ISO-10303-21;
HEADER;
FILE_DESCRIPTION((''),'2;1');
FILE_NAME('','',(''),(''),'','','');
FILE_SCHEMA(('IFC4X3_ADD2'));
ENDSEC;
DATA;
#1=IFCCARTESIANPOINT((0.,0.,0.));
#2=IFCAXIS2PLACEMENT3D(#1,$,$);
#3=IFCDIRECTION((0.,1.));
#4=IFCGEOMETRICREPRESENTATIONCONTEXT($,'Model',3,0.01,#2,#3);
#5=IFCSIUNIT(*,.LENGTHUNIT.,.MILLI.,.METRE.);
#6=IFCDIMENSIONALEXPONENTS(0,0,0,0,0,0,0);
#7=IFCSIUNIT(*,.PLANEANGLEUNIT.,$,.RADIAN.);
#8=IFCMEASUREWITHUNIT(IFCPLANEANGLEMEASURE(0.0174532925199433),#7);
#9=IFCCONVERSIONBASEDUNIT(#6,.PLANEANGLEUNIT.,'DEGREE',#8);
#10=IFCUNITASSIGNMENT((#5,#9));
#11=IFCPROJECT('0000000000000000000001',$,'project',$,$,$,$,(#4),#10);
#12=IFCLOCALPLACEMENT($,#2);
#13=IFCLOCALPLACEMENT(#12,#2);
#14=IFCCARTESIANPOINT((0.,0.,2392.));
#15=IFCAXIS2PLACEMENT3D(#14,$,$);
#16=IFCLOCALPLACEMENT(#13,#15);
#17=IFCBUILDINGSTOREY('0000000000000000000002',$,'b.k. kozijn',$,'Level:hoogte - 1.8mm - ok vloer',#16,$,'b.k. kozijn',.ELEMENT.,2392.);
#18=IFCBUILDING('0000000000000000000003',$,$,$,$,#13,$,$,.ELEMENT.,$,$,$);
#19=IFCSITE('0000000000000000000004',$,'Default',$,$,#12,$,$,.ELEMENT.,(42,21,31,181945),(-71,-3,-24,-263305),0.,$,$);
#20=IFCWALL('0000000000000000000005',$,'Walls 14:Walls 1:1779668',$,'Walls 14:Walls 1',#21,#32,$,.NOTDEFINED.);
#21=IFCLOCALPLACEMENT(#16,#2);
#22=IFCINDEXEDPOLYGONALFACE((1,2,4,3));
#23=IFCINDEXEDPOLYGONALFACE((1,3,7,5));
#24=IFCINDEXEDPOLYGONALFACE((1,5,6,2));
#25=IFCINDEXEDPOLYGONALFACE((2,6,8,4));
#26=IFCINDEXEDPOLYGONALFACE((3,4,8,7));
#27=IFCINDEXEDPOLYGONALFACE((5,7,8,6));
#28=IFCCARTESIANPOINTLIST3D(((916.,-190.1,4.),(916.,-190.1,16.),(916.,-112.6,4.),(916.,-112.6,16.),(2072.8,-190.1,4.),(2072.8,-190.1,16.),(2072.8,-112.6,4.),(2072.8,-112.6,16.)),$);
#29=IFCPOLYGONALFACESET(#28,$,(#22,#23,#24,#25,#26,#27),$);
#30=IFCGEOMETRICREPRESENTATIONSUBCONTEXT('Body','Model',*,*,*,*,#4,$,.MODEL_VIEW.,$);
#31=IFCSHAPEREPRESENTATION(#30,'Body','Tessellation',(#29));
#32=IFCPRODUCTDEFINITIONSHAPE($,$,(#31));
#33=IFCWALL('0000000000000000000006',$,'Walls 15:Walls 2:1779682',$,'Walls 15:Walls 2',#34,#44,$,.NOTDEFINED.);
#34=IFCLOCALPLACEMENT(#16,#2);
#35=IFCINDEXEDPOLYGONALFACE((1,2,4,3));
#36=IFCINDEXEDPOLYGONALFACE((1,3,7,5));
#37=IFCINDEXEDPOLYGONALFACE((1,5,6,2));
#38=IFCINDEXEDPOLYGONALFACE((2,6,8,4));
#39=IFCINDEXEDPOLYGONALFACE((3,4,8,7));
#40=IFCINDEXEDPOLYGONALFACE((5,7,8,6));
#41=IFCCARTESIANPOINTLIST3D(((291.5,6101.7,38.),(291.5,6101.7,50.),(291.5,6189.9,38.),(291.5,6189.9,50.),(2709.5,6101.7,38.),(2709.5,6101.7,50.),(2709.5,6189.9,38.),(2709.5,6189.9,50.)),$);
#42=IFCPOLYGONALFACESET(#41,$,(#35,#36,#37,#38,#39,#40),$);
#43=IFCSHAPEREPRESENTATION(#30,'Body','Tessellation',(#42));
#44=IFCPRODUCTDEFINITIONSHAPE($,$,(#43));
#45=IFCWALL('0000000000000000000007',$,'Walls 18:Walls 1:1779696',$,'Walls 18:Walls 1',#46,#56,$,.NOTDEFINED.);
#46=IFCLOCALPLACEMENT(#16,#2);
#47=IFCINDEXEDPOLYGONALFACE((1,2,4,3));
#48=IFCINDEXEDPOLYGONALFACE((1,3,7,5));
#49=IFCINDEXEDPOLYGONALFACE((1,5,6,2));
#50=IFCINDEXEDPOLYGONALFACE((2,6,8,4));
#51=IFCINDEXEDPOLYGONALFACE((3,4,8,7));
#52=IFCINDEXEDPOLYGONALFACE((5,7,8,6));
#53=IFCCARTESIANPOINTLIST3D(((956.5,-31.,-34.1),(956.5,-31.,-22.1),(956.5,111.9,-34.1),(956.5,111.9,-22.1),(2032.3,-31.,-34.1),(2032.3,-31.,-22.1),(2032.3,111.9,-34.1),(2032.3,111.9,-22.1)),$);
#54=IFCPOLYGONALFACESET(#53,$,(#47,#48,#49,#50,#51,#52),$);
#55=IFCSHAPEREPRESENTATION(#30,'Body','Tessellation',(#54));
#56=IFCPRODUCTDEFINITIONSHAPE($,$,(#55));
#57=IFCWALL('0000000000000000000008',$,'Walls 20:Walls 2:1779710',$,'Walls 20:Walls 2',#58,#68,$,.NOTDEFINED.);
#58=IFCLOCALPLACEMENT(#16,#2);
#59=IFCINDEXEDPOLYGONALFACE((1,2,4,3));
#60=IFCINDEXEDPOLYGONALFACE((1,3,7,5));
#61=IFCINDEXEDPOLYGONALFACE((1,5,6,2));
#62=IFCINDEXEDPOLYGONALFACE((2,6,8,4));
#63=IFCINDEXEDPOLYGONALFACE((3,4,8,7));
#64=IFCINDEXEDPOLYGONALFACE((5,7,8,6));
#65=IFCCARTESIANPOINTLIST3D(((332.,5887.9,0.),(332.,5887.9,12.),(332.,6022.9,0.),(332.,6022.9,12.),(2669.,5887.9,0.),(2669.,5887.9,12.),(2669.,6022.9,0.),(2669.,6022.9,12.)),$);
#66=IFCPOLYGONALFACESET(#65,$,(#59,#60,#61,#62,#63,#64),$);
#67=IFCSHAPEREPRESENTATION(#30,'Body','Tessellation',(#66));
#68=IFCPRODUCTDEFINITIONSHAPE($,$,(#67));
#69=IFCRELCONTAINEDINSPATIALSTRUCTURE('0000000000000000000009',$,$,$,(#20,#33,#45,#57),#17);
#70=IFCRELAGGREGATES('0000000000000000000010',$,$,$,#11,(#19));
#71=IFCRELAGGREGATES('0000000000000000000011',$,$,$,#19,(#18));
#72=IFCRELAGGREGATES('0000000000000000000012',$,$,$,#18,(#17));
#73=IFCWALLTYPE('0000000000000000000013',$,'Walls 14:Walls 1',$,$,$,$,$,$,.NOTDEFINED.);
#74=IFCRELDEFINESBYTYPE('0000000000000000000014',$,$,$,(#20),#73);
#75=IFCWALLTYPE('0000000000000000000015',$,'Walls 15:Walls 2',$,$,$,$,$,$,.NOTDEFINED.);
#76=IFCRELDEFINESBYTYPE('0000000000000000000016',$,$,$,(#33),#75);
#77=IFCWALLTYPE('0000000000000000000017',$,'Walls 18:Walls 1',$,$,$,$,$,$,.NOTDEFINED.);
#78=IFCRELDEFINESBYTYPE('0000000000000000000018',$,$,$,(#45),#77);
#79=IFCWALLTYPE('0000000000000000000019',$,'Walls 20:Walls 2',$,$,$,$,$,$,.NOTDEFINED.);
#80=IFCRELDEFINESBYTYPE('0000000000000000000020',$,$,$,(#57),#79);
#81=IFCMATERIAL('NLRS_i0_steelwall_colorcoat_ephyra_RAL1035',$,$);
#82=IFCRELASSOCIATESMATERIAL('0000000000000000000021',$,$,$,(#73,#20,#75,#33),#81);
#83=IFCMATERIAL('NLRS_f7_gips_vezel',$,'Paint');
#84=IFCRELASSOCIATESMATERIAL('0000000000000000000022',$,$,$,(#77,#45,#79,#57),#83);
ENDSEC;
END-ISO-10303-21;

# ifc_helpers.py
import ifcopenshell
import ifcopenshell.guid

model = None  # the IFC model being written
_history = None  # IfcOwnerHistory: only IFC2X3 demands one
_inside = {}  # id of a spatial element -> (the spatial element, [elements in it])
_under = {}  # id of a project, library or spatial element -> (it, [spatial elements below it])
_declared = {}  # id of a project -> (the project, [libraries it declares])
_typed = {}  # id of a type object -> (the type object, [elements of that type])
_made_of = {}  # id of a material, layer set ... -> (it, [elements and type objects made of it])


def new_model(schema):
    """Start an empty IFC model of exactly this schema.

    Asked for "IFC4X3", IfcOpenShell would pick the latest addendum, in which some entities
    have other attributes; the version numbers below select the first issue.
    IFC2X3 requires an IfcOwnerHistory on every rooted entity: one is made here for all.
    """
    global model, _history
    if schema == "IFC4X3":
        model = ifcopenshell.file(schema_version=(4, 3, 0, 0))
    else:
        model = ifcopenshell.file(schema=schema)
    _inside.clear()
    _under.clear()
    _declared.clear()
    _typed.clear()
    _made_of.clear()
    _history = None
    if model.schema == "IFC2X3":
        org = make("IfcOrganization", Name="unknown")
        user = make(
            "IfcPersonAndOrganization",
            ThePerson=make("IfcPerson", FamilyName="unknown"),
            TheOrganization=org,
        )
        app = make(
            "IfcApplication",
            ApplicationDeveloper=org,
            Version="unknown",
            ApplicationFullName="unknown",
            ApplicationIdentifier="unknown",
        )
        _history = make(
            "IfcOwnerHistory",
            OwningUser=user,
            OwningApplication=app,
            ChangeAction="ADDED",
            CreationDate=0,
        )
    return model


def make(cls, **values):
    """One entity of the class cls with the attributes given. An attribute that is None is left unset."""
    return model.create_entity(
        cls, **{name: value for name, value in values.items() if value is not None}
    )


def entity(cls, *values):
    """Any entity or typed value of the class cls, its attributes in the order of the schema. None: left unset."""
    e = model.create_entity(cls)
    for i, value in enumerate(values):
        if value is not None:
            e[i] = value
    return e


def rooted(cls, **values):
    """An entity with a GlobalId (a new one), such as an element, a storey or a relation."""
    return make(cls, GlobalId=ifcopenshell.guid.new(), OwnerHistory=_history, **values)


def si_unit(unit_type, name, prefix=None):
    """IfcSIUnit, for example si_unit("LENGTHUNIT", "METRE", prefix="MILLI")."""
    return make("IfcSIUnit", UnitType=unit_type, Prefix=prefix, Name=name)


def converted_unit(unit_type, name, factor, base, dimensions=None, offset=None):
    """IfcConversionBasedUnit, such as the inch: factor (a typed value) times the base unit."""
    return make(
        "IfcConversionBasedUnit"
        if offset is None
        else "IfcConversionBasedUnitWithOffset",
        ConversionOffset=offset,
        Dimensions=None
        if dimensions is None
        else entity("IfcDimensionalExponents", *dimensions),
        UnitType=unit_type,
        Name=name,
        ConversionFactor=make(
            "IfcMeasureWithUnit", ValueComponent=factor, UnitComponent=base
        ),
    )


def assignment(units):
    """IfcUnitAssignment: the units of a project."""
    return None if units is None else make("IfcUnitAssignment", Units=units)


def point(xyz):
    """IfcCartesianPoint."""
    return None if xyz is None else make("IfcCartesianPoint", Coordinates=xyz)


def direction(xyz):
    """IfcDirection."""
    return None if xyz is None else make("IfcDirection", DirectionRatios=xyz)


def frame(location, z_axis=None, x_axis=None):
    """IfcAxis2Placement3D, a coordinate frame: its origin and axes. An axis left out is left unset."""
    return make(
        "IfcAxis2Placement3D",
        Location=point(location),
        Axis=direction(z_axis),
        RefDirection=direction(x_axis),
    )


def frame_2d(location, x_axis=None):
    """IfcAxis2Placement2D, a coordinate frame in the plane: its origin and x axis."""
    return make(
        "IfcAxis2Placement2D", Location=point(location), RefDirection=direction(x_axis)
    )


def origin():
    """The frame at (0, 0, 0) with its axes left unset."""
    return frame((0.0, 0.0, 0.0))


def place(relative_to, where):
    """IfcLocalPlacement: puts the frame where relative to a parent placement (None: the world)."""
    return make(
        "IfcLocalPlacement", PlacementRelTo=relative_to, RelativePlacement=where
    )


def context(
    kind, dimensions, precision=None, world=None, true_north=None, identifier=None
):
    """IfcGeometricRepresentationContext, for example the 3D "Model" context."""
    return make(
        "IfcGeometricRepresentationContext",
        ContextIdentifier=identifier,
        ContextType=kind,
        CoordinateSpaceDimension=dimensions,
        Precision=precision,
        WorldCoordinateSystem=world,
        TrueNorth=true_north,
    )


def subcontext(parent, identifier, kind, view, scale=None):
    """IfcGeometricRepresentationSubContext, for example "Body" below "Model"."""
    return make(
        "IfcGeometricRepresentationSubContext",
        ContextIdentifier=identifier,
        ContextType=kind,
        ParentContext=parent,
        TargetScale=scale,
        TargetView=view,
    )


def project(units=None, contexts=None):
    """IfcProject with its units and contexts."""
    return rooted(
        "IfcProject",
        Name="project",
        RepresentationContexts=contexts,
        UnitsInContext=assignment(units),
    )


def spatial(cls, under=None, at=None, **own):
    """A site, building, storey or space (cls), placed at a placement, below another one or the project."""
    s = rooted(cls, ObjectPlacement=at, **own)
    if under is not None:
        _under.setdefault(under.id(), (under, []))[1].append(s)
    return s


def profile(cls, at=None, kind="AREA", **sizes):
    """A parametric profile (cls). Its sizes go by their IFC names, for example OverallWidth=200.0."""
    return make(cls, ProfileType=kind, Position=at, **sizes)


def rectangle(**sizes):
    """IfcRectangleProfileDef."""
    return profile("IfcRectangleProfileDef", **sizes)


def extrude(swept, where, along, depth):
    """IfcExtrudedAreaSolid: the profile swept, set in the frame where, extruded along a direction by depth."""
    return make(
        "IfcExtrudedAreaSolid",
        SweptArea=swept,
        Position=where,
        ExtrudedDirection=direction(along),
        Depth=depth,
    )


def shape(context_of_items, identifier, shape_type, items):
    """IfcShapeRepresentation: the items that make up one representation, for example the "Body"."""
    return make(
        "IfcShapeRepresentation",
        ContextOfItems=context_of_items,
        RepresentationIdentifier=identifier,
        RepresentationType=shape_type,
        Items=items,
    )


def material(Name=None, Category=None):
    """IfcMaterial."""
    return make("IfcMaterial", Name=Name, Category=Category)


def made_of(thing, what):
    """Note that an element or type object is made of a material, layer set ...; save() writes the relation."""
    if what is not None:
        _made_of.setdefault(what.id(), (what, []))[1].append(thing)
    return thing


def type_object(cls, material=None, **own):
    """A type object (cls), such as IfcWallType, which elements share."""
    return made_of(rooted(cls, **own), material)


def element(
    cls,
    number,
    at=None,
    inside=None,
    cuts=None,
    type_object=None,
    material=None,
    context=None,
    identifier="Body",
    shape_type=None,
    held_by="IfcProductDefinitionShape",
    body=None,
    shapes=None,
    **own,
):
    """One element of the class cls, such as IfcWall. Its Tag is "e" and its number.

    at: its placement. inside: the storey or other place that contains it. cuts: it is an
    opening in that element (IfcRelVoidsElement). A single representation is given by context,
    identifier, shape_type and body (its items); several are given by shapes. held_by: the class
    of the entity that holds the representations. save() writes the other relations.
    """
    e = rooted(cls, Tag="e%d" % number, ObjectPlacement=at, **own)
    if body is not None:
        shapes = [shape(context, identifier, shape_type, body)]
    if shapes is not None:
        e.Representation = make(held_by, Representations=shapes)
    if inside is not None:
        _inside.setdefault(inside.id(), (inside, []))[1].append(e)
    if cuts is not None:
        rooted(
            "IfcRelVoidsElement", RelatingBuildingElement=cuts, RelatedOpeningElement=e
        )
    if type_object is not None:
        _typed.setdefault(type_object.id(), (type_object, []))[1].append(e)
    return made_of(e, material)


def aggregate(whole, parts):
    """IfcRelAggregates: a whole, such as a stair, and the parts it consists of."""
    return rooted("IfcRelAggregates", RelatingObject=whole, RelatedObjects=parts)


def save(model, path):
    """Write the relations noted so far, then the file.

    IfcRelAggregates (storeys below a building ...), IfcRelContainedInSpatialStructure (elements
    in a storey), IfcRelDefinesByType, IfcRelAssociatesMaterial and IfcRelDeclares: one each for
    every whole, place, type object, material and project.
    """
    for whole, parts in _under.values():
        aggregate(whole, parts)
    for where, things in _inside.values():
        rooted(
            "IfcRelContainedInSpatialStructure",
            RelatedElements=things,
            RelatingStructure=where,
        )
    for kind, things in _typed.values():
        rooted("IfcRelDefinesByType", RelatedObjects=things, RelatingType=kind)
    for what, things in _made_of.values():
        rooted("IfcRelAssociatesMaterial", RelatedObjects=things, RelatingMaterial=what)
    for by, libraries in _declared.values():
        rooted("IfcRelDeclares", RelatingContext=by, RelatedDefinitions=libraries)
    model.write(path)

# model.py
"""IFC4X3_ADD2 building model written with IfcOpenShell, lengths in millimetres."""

from ifc_helpers import new_model, entity, si_unit, converted_unit, direction, frame, frame_2d, origin, place, context, subcontext, project, spatial, rectangle, extrude, material, type_object, element, save


model = new_model("IFC4X3_ADD2")

# Units and contexts
model_context = context("Model", 3, precision=0.01, world=origin(), true_north=direction((0.0, 1.0)))
body_context = subcontext(model_context, "Body", "Model", "MODEL_VIEW")
ifc_project = project(units=[si_unit("LENGTHUNIT", "METRE", prefix="MILLI"), converted_unit("PLANEANGLEUNIT", "DEGREE", entity("IfcPlaneAngleMeasure", 0.0174532925199433), si_unit("PLANEANGLEUNIT", "RADIAN"), dimensions=[0, 0, 0, 0, 0, 0, 0])], contexts=[model_context])

# Site, building, storey
site_placement = place(None, origin())
site = spatial("IfcSite", under=ifc_project, at=site_placement, Name="Default", CompositionType="ELEMENT", RefLatitude=(42, 21, 31, 181945), RefLongitude=(-71, -3, -24, -263305), RefElevation=0.0)
building_placement = place(site_placement, origin())
building = spatial("IfcBuilding", under=site, at=building_placement, CompositionType="ELEMENT")
storey_placement = place(building_placement, frame((0.0, 0.0, 2392.0)))
storey = spatial("IfcBuildingStorey", under=building, at=storey_placement, Name="b.k. kozijn", ObjectType="Level:hoogte - 1.8mm - ok vloer", LongName="b.k. kozijn", CompositionType="ELEMENT", Elevation=2392.0)

# Walls
ifc_material_1 = material(Name="NLRS_i0_steelwall_colorcoat_ephyra_RAL1035")
wall_type_1 = type_object("IfcWallType", Name="Walls 14:Walls 1", PredefinedType="NOTDEFINED", material=ifc_material_1)
wall_1_placement = place(storey_placement, frame((916.0, -190.1, 4.0)))
element("IfcWall", 1, at=wall_1_placement, inside=storey, type_object=wall_type_1, material=ifc_material_1, Name="Walls 14:Walls 1:1779668", ObjectType="Walls 14:Walls 1", PredefinedType="NOTDEFINED", context=body_context, shape_type="SweptSolid", body=[
    extrude(rectangle(XDim=77.4, YDim=1156.9, at=frame_2d((0.0, 0.0), x_axis=(1.0, 0.0))), frame((578.4, 38.7, 0.0), z_axis=(0.0, 0.0, 1.0), x_axis=(0.0, 1.0, 0.0)), (0.0, 0.0, 1.0), 12.0),
])
wall_type_2 = type_object("IfcWallType", Name="Walls 15:Walls 2", PredefinedType="NOTDEFINED", material=ifc_material_1)
wall_2_placement = place(storey_placement, frame((291.5, 6101.7, 38.0)))
element("IfcWall", 2, at=wall_2_placement, inside=storey, type_object=wall_type_2, material=ifc_material_1, Name="Walls 15:Walls 2:1779682", ObjectType="Walls 15:Walls 2", PredefinedType="NOTDEFINED", context=body_context, shape_type="SweptSolid", body=[
    extrude(rectangle(XDim=88.2, YDim=2418.0, at=frame_2d((0.0, 0.0), x_axis=(1.0, 0.0))), frame((1209.0, 44.1, 0.0), z_axis=(0.0, 0.0, 1.0), x_axis=(0.0, 1.0, 0.0)), (0.0, 0.0, 1.0), 12.0),
])
ifc_material_2 = material(Name="NLRS_f7_gips_vezel", Category="Paint")
wall_type_3 = type_object("IfcWallType", Name="Walls 18:Walls 1", PredefinedType="NOTDEFINED", material=ifc_material_2)
wall_3_placement = place(storey_placement, frame((956.5, -31.0, -34.1)))
element("IfcWall", 3, at=wall_3_placement, inside=storey, type_object=wall_type_3, material=ifc_material_2, Name="Walls 18:Walls 1:1779696", ObjectType="Walls 18:Walls 1", PredefinedType="NOTDEFINED", context=body_context, shape_type="SweptSolid", body=[
    extrude(rectangle(XDim=142.9, YDim=1075.9, at=frame_2d((0.0, 0.0), x_axis=(1.0, 0.0))), frame((537.9, 71.5, 0.0), z_axis=(0.0, 0.0, 1.0), x_axis=(0.0, 1.0, 0.0)), (0.0, 0.0, 1.0), 12.0),
])
wall_type_4 = type_object("IfcWallType", Name="Walls 20:Walls 2", PredefinedType="NOTDEFINED", material=ifc_material_2)
wall_4_placement = place(storey_placement, frame((332.0, 5887.9, 0.0)))
element("IfcWall", 4, at=wall_4_placement, inside=storey, type_object=wall_type_4, material=ifc_material_2, Name="Walls 20:Walls 2:1779710", ObjectType="Walls 20:Walls 2", PredefinedType="NOTDEFINED", context=body_context, shape_type="SweptSolid", body=[
    extrude(rectangle(XDim=135.0, YDim=2337.0, at=frame_2d((0.0, 0.0), x_axis=(1.0, 0.0))), frame((1168.5, 67.5, 0.0), z_axis=(0.0, 0.0, 1.0), x_axis=(0.0, 1.0, 0.0)), (0.0, 0.0, 1.0), 12.0),
])

save(model, "model.ifc")
